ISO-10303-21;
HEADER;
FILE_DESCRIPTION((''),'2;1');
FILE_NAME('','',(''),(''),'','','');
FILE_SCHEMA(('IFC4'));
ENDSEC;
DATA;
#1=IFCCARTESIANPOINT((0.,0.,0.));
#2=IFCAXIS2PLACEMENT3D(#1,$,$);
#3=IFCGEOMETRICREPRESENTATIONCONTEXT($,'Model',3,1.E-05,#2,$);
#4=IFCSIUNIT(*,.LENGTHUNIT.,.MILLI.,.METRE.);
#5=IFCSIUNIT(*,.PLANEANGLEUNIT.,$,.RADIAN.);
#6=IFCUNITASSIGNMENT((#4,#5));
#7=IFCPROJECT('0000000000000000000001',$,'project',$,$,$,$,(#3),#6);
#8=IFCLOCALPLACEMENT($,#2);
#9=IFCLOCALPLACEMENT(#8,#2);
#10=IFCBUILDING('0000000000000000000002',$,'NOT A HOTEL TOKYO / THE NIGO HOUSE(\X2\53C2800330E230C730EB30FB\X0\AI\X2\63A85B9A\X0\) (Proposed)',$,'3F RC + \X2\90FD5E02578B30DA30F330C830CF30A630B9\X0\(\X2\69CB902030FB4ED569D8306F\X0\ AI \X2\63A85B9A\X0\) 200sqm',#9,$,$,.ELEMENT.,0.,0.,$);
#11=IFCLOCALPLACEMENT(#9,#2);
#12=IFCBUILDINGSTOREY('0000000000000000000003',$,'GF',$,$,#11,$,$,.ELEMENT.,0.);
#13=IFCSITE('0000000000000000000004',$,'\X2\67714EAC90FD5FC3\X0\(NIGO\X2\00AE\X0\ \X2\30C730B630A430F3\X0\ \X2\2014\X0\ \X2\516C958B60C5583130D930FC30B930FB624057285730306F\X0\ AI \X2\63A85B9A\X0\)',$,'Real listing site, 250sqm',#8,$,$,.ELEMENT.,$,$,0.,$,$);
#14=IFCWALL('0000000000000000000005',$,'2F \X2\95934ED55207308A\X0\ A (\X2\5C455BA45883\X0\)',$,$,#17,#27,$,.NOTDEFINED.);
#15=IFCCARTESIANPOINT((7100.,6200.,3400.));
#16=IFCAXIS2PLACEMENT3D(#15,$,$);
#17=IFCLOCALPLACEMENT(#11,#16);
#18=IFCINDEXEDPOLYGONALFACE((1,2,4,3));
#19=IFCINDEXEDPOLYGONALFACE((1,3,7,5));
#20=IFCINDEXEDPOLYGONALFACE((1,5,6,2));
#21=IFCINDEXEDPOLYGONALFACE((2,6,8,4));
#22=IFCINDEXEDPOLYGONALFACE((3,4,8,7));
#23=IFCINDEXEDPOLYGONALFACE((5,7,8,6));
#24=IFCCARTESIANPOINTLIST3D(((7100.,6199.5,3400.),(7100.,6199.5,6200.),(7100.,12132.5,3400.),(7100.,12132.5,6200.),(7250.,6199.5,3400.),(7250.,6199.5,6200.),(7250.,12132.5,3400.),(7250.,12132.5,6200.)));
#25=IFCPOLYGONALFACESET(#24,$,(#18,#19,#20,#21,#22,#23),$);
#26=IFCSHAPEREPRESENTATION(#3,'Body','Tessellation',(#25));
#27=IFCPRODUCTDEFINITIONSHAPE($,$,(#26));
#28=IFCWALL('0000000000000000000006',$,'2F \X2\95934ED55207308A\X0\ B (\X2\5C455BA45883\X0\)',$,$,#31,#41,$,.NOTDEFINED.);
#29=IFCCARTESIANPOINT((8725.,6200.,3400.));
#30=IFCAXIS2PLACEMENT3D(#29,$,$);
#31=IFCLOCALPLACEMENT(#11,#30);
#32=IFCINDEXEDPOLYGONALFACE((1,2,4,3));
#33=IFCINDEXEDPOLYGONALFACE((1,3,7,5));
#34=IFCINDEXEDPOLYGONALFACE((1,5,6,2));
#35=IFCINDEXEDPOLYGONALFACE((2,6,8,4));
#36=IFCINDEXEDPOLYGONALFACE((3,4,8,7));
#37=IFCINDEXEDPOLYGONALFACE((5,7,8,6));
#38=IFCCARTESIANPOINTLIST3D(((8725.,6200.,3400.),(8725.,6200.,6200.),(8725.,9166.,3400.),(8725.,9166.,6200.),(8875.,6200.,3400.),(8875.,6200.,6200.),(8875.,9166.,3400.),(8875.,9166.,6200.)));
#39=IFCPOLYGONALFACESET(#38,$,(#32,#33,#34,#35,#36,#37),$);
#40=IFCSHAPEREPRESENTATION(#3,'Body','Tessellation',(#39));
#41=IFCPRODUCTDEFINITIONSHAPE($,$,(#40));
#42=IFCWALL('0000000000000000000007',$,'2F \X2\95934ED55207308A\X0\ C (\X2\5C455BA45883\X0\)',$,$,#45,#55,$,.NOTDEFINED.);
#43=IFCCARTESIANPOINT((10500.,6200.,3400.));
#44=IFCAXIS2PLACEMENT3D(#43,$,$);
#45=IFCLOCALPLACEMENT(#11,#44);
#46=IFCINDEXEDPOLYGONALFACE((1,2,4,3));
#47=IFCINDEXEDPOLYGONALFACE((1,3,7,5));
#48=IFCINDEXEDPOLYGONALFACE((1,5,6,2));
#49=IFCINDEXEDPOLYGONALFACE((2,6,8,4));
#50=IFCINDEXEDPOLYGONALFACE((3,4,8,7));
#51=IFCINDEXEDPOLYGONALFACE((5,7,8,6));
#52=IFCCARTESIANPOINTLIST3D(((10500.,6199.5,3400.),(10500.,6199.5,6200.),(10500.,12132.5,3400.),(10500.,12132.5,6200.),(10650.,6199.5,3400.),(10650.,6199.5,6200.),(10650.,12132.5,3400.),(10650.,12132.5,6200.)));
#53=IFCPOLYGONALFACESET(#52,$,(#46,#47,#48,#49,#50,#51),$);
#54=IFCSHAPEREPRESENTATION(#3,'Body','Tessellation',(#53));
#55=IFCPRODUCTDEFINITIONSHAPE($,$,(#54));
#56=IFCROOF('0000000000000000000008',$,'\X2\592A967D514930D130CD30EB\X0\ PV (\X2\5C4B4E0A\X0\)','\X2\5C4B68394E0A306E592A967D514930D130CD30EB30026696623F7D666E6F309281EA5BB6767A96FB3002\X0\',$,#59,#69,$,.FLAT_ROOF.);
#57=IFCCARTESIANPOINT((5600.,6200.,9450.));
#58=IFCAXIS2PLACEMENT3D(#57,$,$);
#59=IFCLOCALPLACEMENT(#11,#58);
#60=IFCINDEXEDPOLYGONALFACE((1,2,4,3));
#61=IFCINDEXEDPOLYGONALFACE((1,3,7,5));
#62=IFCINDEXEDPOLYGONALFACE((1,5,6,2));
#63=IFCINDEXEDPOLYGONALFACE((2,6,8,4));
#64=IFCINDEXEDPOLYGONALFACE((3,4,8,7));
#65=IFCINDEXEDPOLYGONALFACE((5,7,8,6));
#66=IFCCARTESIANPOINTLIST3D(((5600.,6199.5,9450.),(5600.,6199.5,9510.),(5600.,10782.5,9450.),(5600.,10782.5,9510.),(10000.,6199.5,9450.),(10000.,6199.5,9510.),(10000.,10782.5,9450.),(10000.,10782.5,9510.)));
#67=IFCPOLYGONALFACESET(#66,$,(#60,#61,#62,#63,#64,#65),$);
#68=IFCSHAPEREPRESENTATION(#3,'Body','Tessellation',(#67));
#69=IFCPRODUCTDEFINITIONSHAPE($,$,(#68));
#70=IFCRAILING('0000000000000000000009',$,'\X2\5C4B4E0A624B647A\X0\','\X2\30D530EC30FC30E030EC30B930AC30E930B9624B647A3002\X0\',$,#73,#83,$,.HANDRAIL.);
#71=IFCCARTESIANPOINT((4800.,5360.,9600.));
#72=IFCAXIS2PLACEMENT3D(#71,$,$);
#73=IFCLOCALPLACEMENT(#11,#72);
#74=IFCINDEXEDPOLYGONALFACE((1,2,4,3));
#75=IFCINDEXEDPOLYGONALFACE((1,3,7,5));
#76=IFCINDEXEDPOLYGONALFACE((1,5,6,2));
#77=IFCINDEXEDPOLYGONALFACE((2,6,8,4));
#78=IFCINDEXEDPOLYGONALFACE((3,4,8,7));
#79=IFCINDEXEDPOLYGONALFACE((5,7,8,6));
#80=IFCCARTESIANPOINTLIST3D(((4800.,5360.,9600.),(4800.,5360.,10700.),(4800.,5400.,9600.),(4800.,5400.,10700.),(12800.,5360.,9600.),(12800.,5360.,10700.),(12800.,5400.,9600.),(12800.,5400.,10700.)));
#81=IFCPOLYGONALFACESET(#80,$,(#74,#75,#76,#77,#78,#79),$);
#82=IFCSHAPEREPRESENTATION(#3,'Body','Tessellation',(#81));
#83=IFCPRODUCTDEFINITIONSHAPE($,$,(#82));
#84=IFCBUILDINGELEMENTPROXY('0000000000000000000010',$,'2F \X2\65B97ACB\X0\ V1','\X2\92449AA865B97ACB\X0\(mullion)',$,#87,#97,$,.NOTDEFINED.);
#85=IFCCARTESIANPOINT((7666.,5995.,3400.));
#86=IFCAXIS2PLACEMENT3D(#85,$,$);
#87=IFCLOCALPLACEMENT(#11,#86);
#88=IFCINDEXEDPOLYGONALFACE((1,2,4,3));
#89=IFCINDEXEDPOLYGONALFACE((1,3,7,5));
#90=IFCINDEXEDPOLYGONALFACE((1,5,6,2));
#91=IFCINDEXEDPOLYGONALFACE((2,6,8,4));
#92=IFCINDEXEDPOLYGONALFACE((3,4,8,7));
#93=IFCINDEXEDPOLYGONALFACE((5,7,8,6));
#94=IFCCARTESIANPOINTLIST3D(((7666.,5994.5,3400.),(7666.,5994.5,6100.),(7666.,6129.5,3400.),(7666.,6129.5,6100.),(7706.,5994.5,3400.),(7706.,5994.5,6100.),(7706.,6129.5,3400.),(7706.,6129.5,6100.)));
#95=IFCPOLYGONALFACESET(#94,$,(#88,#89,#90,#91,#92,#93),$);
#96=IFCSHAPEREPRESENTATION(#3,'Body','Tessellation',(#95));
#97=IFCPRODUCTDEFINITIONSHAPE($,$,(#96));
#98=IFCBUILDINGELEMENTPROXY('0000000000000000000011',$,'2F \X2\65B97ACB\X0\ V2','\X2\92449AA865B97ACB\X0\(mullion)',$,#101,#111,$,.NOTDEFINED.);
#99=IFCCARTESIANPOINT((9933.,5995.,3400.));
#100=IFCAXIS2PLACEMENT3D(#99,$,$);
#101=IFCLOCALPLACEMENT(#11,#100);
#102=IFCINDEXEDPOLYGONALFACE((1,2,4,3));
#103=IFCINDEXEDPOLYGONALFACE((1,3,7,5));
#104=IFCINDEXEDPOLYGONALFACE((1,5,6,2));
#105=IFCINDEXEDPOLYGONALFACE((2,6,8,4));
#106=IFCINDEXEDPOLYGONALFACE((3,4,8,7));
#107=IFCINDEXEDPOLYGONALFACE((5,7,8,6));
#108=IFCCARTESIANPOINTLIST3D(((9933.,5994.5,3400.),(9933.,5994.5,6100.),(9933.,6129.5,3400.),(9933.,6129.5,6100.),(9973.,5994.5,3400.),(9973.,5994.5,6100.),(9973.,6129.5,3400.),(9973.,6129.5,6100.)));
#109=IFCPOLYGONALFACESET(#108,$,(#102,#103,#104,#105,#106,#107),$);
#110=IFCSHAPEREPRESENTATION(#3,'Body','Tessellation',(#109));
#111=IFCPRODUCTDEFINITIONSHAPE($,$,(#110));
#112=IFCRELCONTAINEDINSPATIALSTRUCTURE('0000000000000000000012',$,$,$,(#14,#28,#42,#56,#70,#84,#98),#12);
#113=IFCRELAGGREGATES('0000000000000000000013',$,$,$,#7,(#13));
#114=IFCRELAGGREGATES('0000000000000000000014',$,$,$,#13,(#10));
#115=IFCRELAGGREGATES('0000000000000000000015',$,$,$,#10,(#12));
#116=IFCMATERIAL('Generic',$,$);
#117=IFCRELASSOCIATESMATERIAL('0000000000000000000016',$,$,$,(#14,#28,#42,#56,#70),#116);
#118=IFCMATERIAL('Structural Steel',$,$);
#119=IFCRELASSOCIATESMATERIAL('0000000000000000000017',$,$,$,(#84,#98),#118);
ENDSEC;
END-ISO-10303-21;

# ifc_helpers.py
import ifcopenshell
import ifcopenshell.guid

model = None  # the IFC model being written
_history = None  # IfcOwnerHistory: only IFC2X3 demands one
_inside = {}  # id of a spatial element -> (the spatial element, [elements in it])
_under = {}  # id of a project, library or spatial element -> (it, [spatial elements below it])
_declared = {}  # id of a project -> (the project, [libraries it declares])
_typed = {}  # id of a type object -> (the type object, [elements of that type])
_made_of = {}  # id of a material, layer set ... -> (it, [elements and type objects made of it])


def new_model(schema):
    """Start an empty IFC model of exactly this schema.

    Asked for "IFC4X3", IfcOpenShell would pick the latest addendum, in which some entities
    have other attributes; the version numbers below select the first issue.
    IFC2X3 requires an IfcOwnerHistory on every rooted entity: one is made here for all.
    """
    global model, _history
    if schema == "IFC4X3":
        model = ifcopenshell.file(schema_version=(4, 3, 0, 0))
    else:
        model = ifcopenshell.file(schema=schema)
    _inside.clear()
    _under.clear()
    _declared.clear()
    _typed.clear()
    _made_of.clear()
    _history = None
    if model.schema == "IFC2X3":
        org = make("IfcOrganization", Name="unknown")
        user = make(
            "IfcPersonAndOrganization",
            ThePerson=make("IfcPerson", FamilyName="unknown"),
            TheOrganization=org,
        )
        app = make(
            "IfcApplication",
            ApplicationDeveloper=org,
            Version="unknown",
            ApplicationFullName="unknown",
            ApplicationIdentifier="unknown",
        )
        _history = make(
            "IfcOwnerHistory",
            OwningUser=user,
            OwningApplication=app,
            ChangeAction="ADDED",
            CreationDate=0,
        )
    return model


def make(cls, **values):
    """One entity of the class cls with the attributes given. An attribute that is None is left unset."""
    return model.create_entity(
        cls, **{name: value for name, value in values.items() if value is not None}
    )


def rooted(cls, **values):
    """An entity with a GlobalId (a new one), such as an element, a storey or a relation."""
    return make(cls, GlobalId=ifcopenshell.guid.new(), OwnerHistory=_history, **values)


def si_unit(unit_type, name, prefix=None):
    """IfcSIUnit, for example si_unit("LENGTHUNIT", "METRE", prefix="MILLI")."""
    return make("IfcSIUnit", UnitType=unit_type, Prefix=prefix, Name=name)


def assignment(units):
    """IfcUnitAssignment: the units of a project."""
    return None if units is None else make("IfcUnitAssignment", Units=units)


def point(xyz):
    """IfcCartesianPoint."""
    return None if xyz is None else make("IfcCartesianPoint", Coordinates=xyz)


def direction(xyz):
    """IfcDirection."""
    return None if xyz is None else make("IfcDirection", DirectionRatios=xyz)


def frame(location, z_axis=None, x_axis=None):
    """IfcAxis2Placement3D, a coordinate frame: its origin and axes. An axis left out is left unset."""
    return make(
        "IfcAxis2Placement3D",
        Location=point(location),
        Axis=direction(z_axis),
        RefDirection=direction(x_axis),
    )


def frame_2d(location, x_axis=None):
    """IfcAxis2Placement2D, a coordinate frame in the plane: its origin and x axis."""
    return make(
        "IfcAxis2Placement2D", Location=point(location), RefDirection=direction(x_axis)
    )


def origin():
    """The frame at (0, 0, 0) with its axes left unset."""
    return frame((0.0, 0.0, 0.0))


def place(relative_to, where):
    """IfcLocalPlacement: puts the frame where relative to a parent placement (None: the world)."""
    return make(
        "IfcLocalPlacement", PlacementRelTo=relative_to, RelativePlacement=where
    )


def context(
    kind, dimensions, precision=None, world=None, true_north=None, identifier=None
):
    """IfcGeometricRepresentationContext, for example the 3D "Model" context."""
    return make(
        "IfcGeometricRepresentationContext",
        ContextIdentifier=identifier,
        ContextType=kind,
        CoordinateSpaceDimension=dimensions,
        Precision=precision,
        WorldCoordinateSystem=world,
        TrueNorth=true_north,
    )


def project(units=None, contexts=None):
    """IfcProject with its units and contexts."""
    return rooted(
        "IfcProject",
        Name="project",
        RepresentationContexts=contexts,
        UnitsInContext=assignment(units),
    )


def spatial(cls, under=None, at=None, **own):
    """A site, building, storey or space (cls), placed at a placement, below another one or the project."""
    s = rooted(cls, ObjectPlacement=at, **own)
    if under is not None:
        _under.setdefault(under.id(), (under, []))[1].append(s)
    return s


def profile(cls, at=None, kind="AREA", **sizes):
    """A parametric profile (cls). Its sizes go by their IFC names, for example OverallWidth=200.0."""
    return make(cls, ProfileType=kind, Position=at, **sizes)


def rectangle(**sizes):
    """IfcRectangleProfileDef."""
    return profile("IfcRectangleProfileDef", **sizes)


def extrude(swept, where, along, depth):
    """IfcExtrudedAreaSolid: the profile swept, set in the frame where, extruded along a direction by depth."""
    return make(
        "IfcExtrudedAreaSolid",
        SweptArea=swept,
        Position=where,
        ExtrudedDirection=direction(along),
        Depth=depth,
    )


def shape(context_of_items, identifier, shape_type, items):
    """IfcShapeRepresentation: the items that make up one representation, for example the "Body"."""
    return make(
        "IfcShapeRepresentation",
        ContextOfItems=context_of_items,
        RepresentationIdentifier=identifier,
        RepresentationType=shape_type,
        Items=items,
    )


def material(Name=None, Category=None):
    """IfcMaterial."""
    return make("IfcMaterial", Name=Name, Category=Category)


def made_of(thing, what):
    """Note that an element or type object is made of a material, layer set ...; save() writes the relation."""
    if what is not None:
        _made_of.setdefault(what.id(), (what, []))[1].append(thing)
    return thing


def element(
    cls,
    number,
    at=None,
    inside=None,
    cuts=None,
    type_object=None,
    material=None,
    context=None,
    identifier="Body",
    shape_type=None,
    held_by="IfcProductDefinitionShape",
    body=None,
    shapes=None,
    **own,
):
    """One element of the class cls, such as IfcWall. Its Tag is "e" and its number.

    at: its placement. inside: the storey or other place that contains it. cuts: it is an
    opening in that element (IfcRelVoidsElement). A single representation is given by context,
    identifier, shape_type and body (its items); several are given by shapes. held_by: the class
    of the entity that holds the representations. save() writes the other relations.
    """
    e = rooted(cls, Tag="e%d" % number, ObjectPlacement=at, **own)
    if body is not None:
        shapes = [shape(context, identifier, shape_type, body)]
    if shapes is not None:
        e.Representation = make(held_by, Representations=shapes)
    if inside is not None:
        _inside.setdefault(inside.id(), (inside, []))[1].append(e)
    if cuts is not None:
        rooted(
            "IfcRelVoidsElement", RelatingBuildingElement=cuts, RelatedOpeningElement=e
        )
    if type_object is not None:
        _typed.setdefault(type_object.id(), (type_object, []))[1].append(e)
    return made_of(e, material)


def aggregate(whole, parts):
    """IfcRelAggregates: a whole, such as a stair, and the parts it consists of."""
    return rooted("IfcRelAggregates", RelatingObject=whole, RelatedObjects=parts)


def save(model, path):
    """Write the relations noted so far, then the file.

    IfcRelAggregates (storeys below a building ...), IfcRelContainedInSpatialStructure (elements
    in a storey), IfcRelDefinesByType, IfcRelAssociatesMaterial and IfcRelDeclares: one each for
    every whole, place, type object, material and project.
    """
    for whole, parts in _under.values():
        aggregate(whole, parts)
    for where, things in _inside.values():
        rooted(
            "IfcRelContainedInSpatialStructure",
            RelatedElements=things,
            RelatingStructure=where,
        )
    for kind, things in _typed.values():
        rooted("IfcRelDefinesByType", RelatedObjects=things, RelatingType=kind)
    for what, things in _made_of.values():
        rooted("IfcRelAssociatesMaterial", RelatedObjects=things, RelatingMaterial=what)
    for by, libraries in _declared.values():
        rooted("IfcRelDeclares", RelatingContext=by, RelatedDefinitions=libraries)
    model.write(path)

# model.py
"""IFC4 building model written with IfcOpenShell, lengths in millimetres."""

from ifc_helpers import new_model, si_unit, frame, frame_2d, origin, place, context, project, spatial, rectangle, extrude, material, element, save


model = new_model("IFC4")

# Units and contexts
model_context = context("Model", 3, precision=1e-05, world=origin())
ifc_project = project(units=[si_unit("LENGTHUNIT", "METRE", prefix="MILLI"), si_unit("PLANEANGLEUNIT", "RADIAN")], contexts=[model_context])

# Site, building, storey
site_placement = place(None, origin())
site = spatial("IfcSite", under=ifc_project, at=site_placement, Name="東京都心(NIGO® デザイン — 公開情報ベース・所在地は AI 推定)", ObjectType="Real listing site, 250sqm", CompositionType="ELEMENT", RefElevation=0.0)
building_placement = place(site_placement, origin())
building = spatial("IfcBuilding", under=site, at=building_placement, Name="NOT A HOTEL TOKYO / THE NIGO HOUSE(参考モデル・AI推定) (Proposed)", ObjectType="3F RC + 都市型ペントハウス(構造・仕様は AI 推定) 200sqm", CompositionType="ELEMENT", ElevationOfRefHeight=0.0, ElevationOfTerrain=0.0)
storey_placement = place(building_placement, origin())
storey = spatial("IfcBuildingStorey", under=building, at=storey_placement, Name="GF", CompositionType="ELEMENT", Elevation=0.0)

# Shared definitions
ifc_material_1 = material(Name="Generic")

# Walls
wall_1_placement = place(storey_placement, frame((7100.0, 6200.0, 3400.0)))
element("IfcWall", 1, at=wall_1_placement, inside=storey, material=ifc_material_1, Name="2F 間仕切り A (居室境)", PredefinedType="NOTDEFINED", context=model_context, shape_type="SweptSolid", body=[
    extrude(rectangle(XDim=150.0, YDim=5933.0, at=frame_2d((75.0, 2966.0))), frame((7100.0, 6200.0, 3400.0)), (0.0, 0.0, 1.0), 2800.0),
])
wall_2_placement = place(storey_placement, frame((8725.0, 6200.0, 3400.0)))
element("IfcWall", 2, at=wall_2_placement, inside=storey, material=ifc_material_1, Name="2F 間仕切り B (居室境)", PredefinedType="NOTDEFINED", context=model_context, shape_type="SweptSolid", body=[
    extrude(rectangle(XDim=150.0, YDim=2966.0, at=frame_2d((75.0, 1483.0))), frame((8725.0, 6200.0, 3400.0)), (0.0, 0.0, 1.0), 2800.0),
])
wall_3_placement = place(storey_placement, frame((10500.0, 6200.0, 3400.0)))
element("IfcWall", 3, at=wall_3_placement, inside=storey, material=ifc_material_1, Name="2F 間仕切り C (居室境)", PredefinedType="NOTDEFINED", context=model_context, shape_type="SweptSolid", body=[
    extrude(rectangle(XDim=150.0, YDim=5933.0, at=frame_2d((75.0, 2966.0))), frame((10500.0, 6200.0, 3400.0)), (0.0, 0.0, 1.0), 2800.0),
])

# Roof
roof_placement = place(storey_placement, frame((5600.0, 6200.0, 9450.0)))
element("IfcRoof", 4, at=roof_placement, inside=storey, material=ifc_material_1, Name="太陽光パネル PV (屋上)", Description="屋根上の太陽光パネル。暖房給湯を自家発電。", PredefinedType="FLAT_ROOF", context=model_context, shape_type="SweptSolid", body=[
    extrude(rectangle(XDim=4400.0, YDim=4583.0, at=frame_2d((2200.0, 2291.0))), frame((5600.0, 6200.0, 9450.0)), (0.0, 0.0, 1.0), 60.0),
])

# Railing
railing_placement = place(storey_placement, frame((4800.0, 5360.0, 9600.0)))
element("IfcRailing", 5, at=railing_placement, inside=storey, material=ifc_material_1, Name="屋上手摺", Description="フレームレスガラス手摺。", PredefinedType="HANDRAIL", context=model_context, shape_type="SweptSolid", body=[
    extrude(rectangle(XDim=8000.0, YDim=40.0, at=frame_2d((4000.0, 20.0))), frame((4800.0, 5360.0, 9600.0)), (0.0, 0.0, 1.0), 1100.0),
])

# Building element proxies
ifc_material_2 = material(Name="Structural Steel")
proxy_1_placement = place(storey_placement, frame((7666.0, 5995.0, 3400.0)))
element("IfcBuildingElementProxy", 6, at=proxy_1_placement, inside=storey, material=ifc_material_2, Name="2F 方立 V1", Description="鉄骨方立(mullion)", PredefinedType="NOTDEFINED", context=model_context, shape_type="SweptSolid", body=[
    extrude(rectangle(XDim=40.0, YDim=135.0, at=frame_2d((20.0, 67.0))), frame((7666.0, 5995.0, 3400.0)), (0.0, 0.0, 1.0), 2700.0),
])
proxy_2_placement = place(storey_placement, frame((9933.0, 5995.0, 3400.0)))
element("IfcBuildingElementProxy", 7, at=proxy_2_placement, inside=storey, material=ifc_material_2, Name="2F 方立 V2", Description="鉄骨方立(mullion)", PredefinedType="NOTDEFINED", context=model_context, shape_type="SweptSolid", body=[
    extrude(rectangle(XDim=40.0, YDim=135.0, at=frame_2d((20.0, 67.0))), frame((9933.0, 5995.0, 3400.0)), (0.0, 0.0, 1.0), 2700.0),
])

save(model, "model.ifc")
